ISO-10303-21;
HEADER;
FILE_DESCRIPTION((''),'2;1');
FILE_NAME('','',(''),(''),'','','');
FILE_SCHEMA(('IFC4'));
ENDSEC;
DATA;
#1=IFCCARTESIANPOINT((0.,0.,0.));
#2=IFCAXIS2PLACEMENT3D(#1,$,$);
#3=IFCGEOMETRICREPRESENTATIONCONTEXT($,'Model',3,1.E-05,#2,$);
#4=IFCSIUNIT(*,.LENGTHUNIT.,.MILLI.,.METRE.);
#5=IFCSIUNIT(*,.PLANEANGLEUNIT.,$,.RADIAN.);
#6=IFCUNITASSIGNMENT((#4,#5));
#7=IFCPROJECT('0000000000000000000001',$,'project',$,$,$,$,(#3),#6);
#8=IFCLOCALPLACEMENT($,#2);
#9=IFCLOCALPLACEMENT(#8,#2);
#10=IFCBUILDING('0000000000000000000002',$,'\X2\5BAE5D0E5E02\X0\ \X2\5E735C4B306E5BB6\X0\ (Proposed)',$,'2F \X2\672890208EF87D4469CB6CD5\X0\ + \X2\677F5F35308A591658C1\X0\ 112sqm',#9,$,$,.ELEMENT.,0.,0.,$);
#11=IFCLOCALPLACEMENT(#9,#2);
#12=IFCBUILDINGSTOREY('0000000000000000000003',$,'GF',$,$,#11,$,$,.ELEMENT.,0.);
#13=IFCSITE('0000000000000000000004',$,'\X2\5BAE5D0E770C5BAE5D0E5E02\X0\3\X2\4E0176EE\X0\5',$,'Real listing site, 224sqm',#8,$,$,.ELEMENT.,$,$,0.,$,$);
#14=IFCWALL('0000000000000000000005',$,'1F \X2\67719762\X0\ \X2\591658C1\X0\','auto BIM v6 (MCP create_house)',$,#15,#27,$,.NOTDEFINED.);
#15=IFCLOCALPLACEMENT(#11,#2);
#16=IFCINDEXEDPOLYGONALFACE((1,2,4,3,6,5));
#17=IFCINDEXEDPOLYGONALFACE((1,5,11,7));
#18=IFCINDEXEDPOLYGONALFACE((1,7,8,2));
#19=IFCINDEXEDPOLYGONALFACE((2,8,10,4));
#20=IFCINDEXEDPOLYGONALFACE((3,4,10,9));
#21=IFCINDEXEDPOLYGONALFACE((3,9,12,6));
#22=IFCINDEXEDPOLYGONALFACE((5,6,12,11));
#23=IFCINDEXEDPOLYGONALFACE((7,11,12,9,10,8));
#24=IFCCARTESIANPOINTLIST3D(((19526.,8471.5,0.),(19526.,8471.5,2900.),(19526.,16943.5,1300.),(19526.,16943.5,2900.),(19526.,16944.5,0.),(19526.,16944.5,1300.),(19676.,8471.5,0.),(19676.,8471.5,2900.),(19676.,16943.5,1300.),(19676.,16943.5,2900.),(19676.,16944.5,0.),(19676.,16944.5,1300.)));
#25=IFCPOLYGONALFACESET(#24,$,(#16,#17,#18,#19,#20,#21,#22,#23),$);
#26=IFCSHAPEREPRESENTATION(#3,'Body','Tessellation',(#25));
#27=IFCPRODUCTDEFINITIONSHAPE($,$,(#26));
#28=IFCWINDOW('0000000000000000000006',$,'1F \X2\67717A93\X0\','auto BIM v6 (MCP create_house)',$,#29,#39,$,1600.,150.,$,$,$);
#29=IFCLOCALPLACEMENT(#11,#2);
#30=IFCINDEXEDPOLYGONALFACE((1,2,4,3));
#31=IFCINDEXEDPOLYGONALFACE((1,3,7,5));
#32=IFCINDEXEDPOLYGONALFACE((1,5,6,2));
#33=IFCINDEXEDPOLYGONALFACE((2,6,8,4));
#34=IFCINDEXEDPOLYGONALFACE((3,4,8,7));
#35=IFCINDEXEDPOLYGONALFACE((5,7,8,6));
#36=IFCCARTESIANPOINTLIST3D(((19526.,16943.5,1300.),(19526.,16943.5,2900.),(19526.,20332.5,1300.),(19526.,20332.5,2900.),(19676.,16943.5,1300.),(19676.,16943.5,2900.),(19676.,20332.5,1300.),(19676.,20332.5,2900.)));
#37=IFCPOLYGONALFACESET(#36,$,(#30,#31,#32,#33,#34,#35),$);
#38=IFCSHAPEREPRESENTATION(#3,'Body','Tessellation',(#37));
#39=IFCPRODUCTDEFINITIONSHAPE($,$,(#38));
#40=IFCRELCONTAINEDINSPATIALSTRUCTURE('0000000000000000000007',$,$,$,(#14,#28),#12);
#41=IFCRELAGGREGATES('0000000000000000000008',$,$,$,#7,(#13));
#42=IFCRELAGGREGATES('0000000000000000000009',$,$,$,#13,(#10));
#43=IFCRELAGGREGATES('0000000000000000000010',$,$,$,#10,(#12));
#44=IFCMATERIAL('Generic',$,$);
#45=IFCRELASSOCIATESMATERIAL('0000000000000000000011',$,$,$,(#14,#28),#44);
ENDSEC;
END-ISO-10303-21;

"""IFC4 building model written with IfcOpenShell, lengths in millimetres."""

from ifc_helpers import new_model, si_unit, frame, frame_2d, origin, place, context, project, spatial, rectangle, extrude, material, element, fill, save


model = new_model("IFC4")

# Units and contexts
model_context = context("Model", 3, precision=1e-05, world=origin())
ifc_project = project(units=[si_unit("LENGTHUNIT", "METRE", prefix="MILLI"), si_unit("PLANEANGLEUNIT", "RADIAN")], contexts=[model_context])

# Site, building, storey
site_placement = place(None, origin())
site = spatial("IfcSite", under=ifc_project, at=site_placement, Name="宮崎県宮崎市3丁目5", ObjectType="Real listing site, 224sqm", CompositionType="ELEMENT", RefElevation=0.0)
building_placement = place(site_placement, origin())
building = spatial("IfcBuilding", under=site, at=building_placement, Name="宮崎市 平屋の家 (Proposed)", ObjectType="2F 木造軸組構法 + 板張り外壁 112sqm", CompositionType="ELEMENT", ElevationOfRefHeight=0.0, ElevationOfTerrain=0.0)
storey_placement = place(building_placement, origin())
storey = spatial("IfcBuildingStorey", under=building, at=storey_placement, Name="GF", CompositionType="ELEMENT", Elevation=0.0)

# Shared definitions
ifc_material = material(Name="Generic")

# Wall, opening, window
wall_1_placement = place(storey_placement, frame((9763.0, 4236.0, 0.0)))
wall_1 = element("IfcWall", 1, at=wall_1_placement, inside=storey, material=ifc_material, Name="1F 東面 外壁", Description="auto BIM v6 (MCP create_house)", PredefinedType="NOTDEFINED", context=model_context, shape_type="SweptSolid", body=[
    extrude(rectangle(XDim=150.0, YDim=8473.0, at=frame_2d((75.0, 4236.0))), frame((9763.0, 4236.0, 0.0)), (0.0, 0.0, 1.0), 2900.0),
])
opening_1_placement = place(storey_placement, frame((9763.0, 8472.0, 650.0)))
opening_1 = element("IfcOpeningElement", 2, at=opening_1_placement, cuts=wall_1, PredefinedType="NOTDEFINED", context=model_context, shape_type="SweptSolid", body=[
    extrude(rectangle(XDim=150.0, YDim=3389.0, at=frame_2d((75.0, 1694.0))), frame((9763.0, 8472.0, 650.0)), (0.0, 0.0, 1.0), 1600.0),
])
window_1_placement = place(storey_placement, frame((9763.0, 8472.0, 650.0)))
window_1 = element("IfcWindow", 3, at=window_1_placement, inside=storey, material=ifc_material, Name="1F 東窓", Description="auto BIM v6 (MCP create_house)", OverallHeight=1600.0, OverallWidth=150.0, context=model_context, shape_type="SweptSolid", body=[
    extrude(rectangle(XDim=150.0, YDim=3389.0, at=frame_2d((75.0, 1694.0))), frame((9763.0, 8472.0, 650.0)), (0.0, 0.0, 1.0), 1600.0),
])
fill(opening_1, window_1)

save(model, "model.ifc")
